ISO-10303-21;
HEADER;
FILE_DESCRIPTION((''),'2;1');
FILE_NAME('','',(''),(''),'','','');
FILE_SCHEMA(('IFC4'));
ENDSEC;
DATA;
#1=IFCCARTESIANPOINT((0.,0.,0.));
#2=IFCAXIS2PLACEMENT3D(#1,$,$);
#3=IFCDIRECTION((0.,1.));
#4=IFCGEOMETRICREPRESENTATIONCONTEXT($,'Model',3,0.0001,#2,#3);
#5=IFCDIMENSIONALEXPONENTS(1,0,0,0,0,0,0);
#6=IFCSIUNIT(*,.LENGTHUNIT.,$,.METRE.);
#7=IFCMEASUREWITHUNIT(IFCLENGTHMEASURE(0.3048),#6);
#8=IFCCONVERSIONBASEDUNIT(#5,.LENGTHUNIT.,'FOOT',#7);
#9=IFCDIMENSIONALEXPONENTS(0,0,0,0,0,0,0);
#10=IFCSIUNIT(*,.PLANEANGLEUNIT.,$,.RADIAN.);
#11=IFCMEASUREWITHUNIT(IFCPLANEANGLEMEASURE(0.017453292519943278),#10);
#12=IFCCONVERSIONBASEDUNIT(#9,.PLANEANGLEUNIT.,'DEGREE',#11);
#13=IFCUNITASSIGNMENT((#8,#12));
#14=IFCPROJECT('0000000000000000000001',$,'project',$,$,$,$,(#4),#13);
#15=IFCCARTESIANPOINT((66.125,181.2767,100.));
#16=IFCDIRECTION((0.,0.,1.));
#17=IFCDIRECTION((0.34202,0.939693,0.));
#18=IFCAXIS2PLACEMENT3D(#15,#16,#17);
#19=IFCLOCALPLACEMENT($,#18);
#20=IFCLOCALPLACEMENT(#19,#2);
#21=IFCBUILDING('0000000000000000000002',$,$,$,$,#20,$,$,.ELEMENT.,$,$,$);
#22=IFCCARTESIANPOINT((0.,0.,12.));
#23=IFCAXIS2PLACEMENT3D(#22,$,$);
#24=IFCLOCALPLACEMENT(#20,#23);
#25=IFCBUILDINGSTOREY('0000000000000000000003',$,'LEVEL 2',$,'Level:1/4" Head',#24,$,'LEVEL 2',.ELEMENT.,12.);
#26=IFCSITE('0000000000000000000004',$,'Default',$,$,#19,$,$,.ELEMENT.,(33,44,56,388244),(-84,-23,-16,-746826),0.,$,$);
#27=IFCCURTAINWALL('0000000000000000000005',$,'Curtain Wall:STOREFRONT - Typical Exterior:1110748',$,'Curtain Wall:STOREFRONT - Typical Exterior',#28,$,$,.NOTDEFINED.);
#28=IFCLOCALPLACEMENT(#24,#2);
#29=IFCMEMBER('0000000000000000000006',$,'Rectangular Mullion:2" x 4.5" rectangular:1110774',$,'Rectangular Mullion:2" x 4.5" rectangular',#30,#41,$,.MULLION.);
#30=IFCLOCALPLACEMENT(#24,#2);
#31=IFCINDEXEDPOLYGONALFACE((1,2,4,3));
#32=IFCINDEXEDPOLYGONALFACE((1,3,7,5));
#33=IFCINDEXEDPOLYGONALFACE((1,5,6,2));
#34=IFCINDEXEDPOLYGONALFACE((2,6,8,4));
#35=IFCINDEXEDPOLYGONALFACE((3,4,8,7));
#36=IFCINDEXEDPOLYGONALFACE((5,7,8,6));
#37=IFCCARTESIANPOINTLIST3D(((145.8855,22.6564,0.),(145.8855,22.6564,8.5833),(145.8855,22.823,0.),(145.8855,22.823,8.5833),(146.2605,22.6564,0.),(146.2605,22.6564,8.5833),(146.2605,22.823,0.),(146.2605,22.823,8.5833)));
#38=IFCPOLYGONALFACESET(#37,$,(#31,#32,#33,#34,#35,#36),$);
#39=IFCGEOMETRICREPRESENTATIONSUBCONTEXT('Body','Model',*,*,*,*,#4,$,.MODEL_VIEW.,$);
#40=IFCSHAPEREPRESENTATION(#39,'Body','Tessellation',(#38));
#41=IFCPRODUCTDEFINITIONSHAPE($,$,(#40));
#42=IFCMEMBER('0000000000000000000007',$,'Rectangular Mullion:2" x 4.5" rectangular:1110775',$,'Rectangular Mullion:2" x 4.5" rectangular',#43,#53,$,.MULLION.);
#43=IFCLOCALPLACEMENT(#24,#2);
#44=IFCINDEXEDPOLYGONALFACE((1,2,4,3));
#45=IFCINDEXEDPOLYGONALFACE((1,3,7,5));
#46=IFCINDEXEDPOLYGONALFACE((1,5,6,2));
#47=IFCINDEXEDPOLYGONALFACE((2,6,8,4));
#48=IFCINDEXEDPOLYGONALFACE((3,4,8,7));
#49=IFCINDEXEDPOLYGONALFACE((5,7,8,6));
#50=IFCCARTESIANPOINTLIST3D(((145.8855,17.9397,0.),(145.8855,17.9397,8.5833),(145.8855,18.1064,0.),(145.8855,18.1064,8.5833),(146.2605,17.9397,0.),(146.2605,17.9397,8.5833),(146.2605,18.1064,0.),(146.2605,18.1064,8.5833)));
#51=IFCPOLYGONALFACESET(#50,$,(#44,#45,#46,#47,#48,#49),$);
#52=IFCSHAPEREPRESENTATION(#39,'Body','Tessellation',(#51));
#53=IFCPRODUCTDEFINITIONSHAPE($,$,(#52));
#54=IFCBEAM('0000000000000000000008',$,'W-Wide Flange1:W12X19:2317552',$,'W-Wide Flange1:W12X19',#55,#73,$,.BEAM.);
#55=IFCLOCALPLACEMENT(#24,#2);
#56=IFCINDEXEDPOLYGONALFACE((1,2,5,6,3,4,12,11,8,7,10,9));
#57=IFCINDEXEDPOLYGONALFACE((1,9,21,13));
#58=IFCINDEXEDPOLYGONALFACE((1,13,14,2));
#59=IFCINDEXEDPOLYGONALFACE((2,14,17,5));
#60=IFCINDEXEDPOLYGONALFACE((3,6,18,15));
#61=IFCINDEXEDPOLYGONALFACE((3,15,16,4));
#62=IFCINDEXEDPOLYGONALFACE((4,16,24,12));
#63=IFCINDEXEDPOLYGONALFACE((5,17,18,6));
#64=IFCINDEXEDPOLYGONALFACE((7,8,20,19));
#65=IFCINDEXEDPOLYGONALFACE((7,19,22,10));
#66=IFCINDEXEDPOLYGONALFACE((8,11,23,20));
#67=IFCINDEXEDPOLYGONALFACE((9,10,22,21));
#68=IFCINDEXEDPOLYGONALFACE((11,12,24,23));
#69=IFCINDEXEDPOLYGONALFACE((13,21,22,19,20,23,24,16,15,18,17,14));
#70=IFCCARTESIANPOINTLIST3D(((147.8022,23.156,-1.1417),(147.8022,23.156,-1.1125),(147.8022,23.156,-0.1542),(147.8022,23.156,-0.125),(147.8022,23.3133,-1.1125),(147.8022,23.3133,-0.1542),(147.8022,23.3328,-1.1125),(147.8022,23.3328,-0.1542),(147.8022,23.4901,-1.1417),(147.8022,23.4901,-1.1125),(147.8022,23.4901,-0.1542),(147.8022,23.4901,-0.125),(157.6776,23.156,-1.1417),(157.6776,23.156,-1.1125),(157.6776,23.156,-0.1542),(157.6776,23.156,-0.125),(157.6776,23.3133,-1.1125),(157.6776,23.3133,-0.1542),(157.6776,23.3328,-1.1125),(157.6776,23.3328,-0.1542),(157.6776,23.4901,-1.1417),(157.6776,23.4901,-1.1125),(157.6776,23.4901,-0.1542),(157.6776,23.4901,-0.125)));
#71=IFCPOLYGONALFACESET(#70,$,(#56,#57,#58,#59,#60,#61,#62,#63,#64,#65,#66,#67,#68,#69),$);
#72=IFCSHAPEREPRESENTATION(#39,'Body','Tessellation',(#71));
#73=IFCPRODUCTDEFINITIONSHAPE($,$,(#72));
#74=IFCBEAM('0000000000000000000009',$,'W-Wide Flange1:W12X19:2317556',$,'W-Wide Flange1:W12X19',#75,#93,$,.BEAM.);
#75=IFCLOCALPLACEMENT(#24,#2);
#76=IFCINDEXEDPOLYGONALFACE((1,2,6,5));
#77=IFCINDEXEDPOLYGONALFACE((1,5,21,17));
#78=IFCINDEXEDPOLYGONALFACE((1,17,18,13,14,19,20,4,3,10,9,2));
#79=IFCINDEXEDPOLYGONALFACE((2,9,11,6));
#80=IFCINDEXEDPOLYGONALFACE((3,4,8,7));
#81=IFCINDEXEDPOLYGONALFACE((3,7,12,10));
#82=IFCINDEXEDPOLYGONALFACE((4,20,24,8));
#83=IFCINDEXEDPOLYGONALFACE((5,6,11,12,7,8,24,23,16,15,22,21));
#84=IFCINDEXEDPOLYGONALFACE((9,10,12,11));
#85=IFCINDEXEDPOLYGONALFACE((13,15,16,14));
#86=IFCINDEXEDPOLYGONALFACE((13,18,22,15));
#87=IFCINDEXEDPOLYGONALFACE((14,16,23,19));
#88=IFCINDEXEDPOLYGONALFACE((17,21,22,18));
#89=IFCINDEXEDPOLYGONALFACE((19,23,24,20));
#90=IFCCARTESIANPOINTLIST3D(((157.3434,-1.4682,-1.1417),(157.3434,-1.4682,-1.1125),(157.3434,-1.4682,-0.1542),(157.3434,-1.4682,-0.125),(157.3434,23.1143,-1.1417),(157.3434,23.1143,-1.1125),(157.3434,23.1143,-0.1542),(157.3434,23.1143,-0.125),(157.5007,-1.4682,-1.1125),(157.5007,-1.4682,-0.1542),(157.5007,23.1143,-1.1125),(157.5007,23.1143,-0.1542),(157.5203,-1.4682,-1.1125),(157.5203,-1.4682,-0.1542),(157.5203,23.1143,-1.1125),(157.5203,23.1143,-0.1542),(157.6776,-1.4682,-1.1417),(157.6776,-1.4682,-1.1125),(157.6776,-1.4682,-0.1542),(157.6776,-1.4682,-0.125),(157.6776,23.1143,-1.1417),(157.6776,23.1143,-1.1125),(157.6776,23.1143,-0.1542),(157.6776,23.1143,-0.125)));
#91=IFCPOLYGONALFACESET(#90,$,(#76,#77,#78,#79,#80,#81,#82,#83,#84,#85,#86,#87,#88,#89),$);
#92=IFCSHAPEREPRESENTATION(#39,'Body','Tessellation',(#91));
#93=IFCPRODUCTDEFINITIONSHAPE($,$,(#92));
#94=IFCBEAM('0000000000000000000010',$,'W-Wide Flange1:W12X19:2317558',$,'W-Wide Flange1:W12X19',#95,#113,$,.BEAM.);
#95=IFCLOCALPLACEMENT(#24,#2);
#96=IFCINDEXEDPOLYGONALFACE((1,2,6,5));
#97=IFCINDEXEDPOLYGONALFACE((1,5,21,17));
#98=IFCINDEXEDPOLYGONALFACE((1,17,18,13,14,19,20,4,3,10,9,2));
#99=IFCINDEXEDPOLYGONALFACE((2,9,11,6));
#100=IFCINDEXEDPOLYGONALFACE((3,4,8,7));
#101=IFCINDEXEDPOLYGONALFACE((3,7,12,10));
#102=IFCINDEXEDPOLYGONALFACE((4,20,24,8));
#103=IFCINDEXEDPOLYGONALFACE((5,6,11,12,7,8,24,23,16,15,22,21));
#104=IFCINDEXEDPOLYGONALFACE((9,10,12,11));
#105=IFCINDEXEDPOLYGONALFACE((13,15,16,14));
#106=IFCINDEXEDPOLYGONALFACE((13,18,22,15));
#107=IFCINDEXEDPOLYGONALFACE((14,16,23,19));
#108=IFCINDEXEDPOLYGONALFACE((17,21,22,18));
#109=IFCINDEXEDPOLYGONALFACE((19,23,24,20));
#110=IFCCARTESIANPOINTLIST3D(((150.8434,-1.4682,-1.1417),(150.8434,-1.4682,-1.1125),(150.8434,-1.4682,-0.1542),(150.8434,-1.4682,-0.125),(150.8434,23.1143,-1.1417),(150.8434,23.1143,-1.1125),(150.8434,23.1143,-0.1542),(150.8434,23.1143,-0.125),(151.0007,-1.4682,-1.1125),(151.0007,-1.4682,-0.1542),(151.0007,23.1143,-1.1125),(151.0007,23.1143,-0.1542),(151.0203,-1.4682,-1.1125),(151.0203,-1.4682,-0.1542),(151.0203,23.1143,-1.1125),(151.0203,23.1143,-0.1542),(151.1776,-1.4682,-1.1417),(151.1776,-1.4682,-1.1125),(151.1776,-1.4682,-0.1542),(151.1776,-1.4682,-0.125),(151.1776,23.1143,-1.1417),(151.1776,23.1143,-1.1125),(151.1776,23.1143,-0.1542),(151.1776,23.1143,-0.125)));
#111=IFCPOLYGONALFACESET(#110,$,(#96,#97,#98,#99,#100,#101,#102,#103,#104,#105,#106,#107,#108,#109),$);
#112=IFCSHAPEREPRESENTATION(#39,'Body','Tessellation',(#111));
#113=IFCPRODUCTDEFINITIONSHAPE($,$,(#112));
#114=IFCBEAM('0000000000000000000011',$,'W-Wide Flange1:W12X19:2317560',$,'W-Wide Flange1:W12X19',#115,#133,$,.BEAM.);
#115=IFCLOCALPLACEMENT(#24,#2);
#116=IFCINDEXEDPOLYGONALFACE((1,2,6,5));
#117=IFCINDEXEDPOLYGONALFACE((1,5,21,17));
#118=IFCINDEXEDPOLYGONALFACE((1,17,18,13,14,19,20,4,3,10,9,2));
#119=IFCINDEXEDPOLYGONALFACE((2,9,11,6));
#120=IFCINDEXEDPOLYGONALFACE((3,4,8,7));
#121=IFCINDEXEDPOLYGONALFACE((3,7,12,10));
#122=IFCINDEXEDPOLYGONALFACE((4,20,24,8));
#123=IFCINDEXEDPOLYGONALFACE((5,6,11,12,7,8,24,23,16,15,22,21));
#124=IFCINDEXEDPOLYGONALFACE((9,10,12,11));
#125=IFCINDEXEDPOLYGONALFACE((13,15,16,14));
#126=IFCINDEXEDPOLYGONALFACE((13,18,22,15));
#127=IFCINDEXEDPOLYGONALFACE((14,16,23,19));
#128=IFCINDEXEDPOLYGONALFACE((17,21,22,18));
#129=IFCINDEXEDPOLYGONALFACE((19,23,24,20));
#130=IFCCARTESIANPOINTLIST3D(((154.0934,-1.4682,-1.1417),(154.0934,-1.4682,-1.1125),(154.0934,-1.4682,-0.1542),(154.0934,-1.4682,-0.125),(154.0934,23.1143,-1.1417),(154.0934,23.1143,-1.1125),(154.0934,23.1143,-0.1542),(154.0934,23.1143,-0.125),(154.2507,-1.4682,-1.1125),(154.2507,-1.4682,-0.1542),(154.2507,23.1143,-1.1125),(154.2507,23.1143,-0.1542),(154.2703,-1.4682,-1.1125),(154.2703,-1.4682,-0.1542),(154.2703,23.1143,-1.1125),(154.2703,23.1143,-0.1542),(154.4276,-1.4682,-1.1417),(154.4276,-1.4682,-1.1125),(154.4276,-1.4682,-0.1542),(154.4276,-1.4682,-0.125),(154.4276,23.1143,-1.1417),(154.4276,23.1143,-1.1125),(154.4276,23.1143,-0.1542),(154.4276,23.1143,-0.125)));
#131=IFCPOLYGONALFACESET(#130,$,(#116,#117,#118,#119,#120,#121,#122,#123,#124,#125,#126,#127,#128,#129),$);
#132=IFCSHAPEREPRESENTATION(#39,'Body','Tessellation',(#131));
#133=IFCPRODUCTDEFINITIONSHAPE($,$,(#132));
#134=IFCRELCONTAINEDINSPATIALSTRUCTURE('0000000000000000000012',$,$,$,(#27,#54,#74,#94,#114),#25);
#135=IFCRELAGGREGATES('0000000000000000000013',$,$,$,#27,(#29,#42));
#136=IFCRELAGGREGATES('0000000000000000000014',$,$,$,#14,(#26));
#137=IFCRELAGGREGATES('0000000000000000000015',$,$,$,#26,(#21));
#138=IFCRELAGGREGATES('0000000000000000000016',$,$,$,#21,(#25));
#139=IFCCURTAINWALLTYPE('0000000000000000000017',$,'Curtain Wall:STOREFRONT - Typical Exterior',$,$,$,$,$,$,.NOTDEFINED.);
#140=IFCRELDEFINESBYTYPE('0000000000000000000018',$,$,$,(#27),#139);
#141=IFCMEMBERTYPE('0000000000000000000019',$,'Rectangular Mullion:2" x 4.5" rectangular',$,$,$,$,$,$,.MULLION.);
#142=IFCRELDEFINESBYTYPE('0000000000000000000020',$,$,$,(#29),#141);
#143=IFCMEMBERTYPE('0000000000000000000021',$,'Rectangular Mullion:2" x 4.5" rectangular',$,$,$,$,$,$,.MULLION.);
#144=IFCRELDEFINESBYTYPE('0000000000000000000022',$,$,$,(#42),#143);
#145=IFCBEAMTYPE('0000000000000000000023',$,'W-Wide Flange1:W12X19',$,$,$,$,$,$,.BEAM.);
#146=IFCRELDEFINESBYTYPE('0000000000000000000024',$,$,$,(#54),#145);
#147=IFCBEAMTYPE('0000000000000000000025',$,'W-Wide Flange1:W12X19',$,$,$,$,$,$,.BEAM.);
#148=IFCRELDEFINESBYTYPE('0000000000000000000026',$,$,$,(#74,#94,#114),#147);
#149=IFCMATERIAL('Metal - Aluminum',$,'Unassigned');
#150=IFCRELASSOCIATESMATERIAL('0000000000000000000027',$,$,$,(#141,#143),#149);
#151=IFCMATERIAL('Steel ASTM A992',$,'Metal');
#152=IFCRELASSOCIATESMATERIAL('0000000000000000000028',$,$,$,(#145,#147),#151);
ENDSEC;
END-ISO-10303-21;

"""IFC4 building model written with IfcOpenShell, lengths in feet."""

from ifc_helpers import new_model, entity, si_unit, converted_unit, direction, frame, frame_2d, origin, origin_2d_with_axis, place, context, subcontext, project, spatial, rectangle, i_section, extrude, source, transform, mapped, material, material_profile, profile_set, type_object, type_shapes, element, aggregate, save


model = new_model("IFC4")

# Units and contexts
model_context = context("Model", 3, precision=0.0001, world=origin(), true_north=direction((0.0, 1.0)))
body_context = subcontext(model_context, "Body", "Model", "MODEL_VIEW")
ifc_project = project(units=[converted_unit("LENGTHUNIT", "FOOT", entity("IfcLengthMeasure", 0.3048), si_unit("LENGTHUNIT", "METRE"), dimensions=[1, 0, 0, 0, 0, 0, 0]), converted_unit("PLANEANGLEUNIT", "DEGREE", entity("IfcPlaneAngleMeasure", 0.017453292519943278), si_unit("PLANEANGLEUNIT", "RADIAN"), dimensions=[0, 0, 0, 0, 0, 0, 0])], contexts=[model_context])

# Site, building, storey
site_placement = place(None, frame((66.125, 181.2767, 100.0), z_axis=(0.0, 0.0, 1.0), x_axis=(0.34202, 0.939693, 0.0)))
site = spatial("IfcSite", under=ifc_project, at=site_placement, Name="Default", CompositionType="ELEMENT", RefLatitude=(33, 44, 56, 388244), RefLongitude=(-84, -23, -16, -746826), RefElevation=0.0)
building_placement = place(site_placement, origin())
building = spatial("IfcBuilding", under=site, at=building_placement, CompositionType="ELEMENT")
storey_placement = place(building_placement, frame((0.0, 0.0, 12.0)))
storey = spatial("IfcBuildingStorey", under=building, at=storey_placement, Name="LEVEL 2", ObjectType="Level:1/4\" Head", LongName="LEVEL 2", CompositionType="ELEMENT", Elevation=12.0)

# Curtain wall
curtain_wall_type = type_object("IfcCurtainWallType", Name="Curtain Wall:STOREFRONT - Typical Exterior", PredefinedType="NOTDEFINED")
curtain_wall_1_placement = place(storey_placement, frame((0.0, 0.0, -12.0)))
curtain_wall_1 = element("IfcCurtainWall", 1, at=curtain_wall_1_placement, inside=storey, type_object=curtain_wall_type, Name="Curtain Wall:STOREFRONT - Typical Exterior:1110748", ObjectType="Curtain Wall:STOREFRONT - Typical Exterior", PredefinedType="NOTDEFINED")
ifc_material_1 = material(Name="Metal - Aluminum", Category="Unassigned")
ifc_material_profile_1 = material_profile(ifc_material_1, rectangle(XDim=0.1667, YDim=0.375, at=origin_2d_with_axis()), Name="2\" x 4.5\" rectangular")
ifc_profile_set_1 = profile_set([ifc_material_profile_1], Name="2\" x 4.5\" rectangular")

# Members
member_type_1 = type_object("IfcMemberType", Name="Rectangular Mullion:2\" x 4.5\" rectangular", PredefinedType="MULLION", material=ifc_profile_set_1)
shared_shape_1 = source(origin(), body_context, "Body", "SweptSolid", [
    extrude(rectangle(XDim=0.1667, YDim=0.375, at=origin_2d_with_axis()), frame((-0.0833, 0.0, -8.5833), z_axis=(0.0, 0.0, 1.0), x_axis=(-1.0, 0.0, 0.0)), (0.0, 0.0, 1.0), 8.5833),
])
type_shapes(member_type_1, [shared_shape_1])
member_1_placement = place(curtain_wall_1_placement, frame((146.073, 22.823, 20.5833), z_axis=(0.0, 0.0, 1.0), x_axis=(0.0, 1.0, 0.0)))
member_1 = element("IfcMember", 2, at=member_1_placement, type_object=member_type_1, Name="Rectangular Mullion:2\" x 4.5\" rectangular:1110774", ObjectType="Rectangular Mullion:2\" x 4.5\" rectangular", PredefinedType="MULLION", context=body_context, shape_type="MappedRepresentation", body=[
    mapped(shared_shape_1, transform((0.0, 0.0, 0.0), scale=1.0)),
])
member_type_2 = type_object("IfcMemberType", Name="Rectangular Mullion:2\" x 4.5\" rectangular", PredefinedType="MULLION", material=ifc_profile_set_1)
shared_shape_2 = source(origin(), body_context, "Body", "SweptSolid", [
    extrude(rectangle(XDim=0.1667, YDim=0.375, at=frame_2d((0.0, 0.0), x_axis=(1.0, 0.0))), frame((0.0, 0.0, -8.5833), z_axis=(0.0, 0.0, 1.0), x_axis=(-1.0, 0.0, 0.0)), (0.0, 0.0, 1.0), 8.5833),
])
type_shapes(member_type_2, [shared_shape_2])
member_2_placement = place(curtain_wall_1_placement, frame((146.073, 18.023, 12.0), z_axis=(0.0, 0.0, -1.0), x_axis=(0.0, -1.0, 0.0)))
member_2 = element("IfcMember", 3, at=member_2_placement, type_object=member_type_2, Name="Rectangular Mullion:2\" x 4.5\" rectangular:1110775", ObjectType="Rectangular Mullion:2\" x 4.5\" rectangular", PredefinedType="MULLION", context=body_context, shape_type="MappedRepresentation", body=[
    mapped(shared_shape_2, transform((0.0, 0.0, 0.0), scale=1.0)),
])

# Beams
ifc_material_2 = material(Name="Steel ASTM A992", Category="Metal")
ifc_material_profile_2 = material_profile(ifc_material_2, i_section(OverallWidth=0.3342, OverallDepth=1.0167, WebThickness=0.0196, FlangeThickness=0.0292, at=frame_2d((0.0, 0.0), x_axis=(0.0, 1.0))), Name="W12X19")
ifc_profile_set_2 = profile_set([ifc_material_profile_2], Name="W12X19")
beam_type_1 = type_object("IfcBeamType", Name="W-Wide Flange1:W12X19", PredefinedType="BEAM", material=ifc_profile_set_2)
shared_shape_3 = source(origin(), body_context, "Body", "SweptSolid", [
    extrude(i_section(OverallWidth=0.3342, OverallDepth=1.0167, WebThickness=0.0196, FlangeThickness=0.0292, at=frame_2d((0.0, 0.0), x_axis=(0.0, 1.0))), frame((-4.3333, 0.0, 0.0), z_axis=(1.0, 0.0, 0.0), x_axis=(0.0, 0.0, -1.0)), (0.0, 0.0, 1.0), 9.8754),
])
type_shapes(beam_type_1, [shared_shape_3])
beam_1_placement = place(storey_placement, frame((152.1355, 23.323, -0.6333)))
element("IfcBeam", 4, at=beam_1_placement, inside=storey, type_object=beam_type_1, Name="W-Wide Flange1:W12X19:2317552", ObjectType="W-Wide Flange1:W12X19", PredefinedType="BEAM", context=body_context, shape_type="MappedRepresentation", body=[
    mapped(shared_shape_3, transform((0.0, 0.0, 0.0), scale=1.0)),
])
beam_type_2 = type_object("IfcBeamType", Name="W-Wide Flange1:W12X19", PredefinedType="BEAM", material=ifc_profile_set_2)
shared_shape_4 = source(origin(), body_context, "Body", "SweptSolid", [
    extrude(i_section(OverallWidth=0.3342, OverallDepth=1.0167, WebThickness=0.0196, FlangeThickness=0.0292, at=frame_2d((0.0, 0.0), x_axis=(0.0, 1.0))), frame((-12.2912, 0.0, 0.0), z_axis=(1.0, 0.0, 0.0), x_axis=(0.0, 0.0, -1.0)), (0.0, 0.0, 1.0), 24.5825),
])
type_shapes(beam_type_2, [shared_shape_4])
for number, where, z_axis, x_axis, name in (
    (5, (157.5105, 10.823, -0.6333), (0.0, 0.0, 1.0), (0.0, 1.0, 0.0), "W-Wide Flange1:W12X19:2317556"),
    (6, (151.0105, 10.823, -0.6333), (0.0, 0.0, 1.0), (0.0, -1.0, 0.0), "W-Wide Flange1:W12X19:2317558"),
    (7, (154.2605, 10.823, -0.6333), (0.0, 0.0, 1.0), (0.0, -1.0, 0.0), "W-Wide Flange1:W12X19:2317560"),
):
    element("IfcBeam", number, at=place(storey_placement, frame(where, z_axis=z_axis, x_axis=x_axis)), inside=storey, type_object=beam_type_2, Name=name, ObjectType="W-Wide Flange1:W12X19", PredefinedType="BEAM", context=body_context, shape_type="MappedRepresentation", body=[
        mapped(shared_shape_4, transform((0.0, 0.0, 0.0), scale=1.0)),
    ])

aggregate(curtain_wall_1, [member_1, member_2])

save(model, "model.ifc")
